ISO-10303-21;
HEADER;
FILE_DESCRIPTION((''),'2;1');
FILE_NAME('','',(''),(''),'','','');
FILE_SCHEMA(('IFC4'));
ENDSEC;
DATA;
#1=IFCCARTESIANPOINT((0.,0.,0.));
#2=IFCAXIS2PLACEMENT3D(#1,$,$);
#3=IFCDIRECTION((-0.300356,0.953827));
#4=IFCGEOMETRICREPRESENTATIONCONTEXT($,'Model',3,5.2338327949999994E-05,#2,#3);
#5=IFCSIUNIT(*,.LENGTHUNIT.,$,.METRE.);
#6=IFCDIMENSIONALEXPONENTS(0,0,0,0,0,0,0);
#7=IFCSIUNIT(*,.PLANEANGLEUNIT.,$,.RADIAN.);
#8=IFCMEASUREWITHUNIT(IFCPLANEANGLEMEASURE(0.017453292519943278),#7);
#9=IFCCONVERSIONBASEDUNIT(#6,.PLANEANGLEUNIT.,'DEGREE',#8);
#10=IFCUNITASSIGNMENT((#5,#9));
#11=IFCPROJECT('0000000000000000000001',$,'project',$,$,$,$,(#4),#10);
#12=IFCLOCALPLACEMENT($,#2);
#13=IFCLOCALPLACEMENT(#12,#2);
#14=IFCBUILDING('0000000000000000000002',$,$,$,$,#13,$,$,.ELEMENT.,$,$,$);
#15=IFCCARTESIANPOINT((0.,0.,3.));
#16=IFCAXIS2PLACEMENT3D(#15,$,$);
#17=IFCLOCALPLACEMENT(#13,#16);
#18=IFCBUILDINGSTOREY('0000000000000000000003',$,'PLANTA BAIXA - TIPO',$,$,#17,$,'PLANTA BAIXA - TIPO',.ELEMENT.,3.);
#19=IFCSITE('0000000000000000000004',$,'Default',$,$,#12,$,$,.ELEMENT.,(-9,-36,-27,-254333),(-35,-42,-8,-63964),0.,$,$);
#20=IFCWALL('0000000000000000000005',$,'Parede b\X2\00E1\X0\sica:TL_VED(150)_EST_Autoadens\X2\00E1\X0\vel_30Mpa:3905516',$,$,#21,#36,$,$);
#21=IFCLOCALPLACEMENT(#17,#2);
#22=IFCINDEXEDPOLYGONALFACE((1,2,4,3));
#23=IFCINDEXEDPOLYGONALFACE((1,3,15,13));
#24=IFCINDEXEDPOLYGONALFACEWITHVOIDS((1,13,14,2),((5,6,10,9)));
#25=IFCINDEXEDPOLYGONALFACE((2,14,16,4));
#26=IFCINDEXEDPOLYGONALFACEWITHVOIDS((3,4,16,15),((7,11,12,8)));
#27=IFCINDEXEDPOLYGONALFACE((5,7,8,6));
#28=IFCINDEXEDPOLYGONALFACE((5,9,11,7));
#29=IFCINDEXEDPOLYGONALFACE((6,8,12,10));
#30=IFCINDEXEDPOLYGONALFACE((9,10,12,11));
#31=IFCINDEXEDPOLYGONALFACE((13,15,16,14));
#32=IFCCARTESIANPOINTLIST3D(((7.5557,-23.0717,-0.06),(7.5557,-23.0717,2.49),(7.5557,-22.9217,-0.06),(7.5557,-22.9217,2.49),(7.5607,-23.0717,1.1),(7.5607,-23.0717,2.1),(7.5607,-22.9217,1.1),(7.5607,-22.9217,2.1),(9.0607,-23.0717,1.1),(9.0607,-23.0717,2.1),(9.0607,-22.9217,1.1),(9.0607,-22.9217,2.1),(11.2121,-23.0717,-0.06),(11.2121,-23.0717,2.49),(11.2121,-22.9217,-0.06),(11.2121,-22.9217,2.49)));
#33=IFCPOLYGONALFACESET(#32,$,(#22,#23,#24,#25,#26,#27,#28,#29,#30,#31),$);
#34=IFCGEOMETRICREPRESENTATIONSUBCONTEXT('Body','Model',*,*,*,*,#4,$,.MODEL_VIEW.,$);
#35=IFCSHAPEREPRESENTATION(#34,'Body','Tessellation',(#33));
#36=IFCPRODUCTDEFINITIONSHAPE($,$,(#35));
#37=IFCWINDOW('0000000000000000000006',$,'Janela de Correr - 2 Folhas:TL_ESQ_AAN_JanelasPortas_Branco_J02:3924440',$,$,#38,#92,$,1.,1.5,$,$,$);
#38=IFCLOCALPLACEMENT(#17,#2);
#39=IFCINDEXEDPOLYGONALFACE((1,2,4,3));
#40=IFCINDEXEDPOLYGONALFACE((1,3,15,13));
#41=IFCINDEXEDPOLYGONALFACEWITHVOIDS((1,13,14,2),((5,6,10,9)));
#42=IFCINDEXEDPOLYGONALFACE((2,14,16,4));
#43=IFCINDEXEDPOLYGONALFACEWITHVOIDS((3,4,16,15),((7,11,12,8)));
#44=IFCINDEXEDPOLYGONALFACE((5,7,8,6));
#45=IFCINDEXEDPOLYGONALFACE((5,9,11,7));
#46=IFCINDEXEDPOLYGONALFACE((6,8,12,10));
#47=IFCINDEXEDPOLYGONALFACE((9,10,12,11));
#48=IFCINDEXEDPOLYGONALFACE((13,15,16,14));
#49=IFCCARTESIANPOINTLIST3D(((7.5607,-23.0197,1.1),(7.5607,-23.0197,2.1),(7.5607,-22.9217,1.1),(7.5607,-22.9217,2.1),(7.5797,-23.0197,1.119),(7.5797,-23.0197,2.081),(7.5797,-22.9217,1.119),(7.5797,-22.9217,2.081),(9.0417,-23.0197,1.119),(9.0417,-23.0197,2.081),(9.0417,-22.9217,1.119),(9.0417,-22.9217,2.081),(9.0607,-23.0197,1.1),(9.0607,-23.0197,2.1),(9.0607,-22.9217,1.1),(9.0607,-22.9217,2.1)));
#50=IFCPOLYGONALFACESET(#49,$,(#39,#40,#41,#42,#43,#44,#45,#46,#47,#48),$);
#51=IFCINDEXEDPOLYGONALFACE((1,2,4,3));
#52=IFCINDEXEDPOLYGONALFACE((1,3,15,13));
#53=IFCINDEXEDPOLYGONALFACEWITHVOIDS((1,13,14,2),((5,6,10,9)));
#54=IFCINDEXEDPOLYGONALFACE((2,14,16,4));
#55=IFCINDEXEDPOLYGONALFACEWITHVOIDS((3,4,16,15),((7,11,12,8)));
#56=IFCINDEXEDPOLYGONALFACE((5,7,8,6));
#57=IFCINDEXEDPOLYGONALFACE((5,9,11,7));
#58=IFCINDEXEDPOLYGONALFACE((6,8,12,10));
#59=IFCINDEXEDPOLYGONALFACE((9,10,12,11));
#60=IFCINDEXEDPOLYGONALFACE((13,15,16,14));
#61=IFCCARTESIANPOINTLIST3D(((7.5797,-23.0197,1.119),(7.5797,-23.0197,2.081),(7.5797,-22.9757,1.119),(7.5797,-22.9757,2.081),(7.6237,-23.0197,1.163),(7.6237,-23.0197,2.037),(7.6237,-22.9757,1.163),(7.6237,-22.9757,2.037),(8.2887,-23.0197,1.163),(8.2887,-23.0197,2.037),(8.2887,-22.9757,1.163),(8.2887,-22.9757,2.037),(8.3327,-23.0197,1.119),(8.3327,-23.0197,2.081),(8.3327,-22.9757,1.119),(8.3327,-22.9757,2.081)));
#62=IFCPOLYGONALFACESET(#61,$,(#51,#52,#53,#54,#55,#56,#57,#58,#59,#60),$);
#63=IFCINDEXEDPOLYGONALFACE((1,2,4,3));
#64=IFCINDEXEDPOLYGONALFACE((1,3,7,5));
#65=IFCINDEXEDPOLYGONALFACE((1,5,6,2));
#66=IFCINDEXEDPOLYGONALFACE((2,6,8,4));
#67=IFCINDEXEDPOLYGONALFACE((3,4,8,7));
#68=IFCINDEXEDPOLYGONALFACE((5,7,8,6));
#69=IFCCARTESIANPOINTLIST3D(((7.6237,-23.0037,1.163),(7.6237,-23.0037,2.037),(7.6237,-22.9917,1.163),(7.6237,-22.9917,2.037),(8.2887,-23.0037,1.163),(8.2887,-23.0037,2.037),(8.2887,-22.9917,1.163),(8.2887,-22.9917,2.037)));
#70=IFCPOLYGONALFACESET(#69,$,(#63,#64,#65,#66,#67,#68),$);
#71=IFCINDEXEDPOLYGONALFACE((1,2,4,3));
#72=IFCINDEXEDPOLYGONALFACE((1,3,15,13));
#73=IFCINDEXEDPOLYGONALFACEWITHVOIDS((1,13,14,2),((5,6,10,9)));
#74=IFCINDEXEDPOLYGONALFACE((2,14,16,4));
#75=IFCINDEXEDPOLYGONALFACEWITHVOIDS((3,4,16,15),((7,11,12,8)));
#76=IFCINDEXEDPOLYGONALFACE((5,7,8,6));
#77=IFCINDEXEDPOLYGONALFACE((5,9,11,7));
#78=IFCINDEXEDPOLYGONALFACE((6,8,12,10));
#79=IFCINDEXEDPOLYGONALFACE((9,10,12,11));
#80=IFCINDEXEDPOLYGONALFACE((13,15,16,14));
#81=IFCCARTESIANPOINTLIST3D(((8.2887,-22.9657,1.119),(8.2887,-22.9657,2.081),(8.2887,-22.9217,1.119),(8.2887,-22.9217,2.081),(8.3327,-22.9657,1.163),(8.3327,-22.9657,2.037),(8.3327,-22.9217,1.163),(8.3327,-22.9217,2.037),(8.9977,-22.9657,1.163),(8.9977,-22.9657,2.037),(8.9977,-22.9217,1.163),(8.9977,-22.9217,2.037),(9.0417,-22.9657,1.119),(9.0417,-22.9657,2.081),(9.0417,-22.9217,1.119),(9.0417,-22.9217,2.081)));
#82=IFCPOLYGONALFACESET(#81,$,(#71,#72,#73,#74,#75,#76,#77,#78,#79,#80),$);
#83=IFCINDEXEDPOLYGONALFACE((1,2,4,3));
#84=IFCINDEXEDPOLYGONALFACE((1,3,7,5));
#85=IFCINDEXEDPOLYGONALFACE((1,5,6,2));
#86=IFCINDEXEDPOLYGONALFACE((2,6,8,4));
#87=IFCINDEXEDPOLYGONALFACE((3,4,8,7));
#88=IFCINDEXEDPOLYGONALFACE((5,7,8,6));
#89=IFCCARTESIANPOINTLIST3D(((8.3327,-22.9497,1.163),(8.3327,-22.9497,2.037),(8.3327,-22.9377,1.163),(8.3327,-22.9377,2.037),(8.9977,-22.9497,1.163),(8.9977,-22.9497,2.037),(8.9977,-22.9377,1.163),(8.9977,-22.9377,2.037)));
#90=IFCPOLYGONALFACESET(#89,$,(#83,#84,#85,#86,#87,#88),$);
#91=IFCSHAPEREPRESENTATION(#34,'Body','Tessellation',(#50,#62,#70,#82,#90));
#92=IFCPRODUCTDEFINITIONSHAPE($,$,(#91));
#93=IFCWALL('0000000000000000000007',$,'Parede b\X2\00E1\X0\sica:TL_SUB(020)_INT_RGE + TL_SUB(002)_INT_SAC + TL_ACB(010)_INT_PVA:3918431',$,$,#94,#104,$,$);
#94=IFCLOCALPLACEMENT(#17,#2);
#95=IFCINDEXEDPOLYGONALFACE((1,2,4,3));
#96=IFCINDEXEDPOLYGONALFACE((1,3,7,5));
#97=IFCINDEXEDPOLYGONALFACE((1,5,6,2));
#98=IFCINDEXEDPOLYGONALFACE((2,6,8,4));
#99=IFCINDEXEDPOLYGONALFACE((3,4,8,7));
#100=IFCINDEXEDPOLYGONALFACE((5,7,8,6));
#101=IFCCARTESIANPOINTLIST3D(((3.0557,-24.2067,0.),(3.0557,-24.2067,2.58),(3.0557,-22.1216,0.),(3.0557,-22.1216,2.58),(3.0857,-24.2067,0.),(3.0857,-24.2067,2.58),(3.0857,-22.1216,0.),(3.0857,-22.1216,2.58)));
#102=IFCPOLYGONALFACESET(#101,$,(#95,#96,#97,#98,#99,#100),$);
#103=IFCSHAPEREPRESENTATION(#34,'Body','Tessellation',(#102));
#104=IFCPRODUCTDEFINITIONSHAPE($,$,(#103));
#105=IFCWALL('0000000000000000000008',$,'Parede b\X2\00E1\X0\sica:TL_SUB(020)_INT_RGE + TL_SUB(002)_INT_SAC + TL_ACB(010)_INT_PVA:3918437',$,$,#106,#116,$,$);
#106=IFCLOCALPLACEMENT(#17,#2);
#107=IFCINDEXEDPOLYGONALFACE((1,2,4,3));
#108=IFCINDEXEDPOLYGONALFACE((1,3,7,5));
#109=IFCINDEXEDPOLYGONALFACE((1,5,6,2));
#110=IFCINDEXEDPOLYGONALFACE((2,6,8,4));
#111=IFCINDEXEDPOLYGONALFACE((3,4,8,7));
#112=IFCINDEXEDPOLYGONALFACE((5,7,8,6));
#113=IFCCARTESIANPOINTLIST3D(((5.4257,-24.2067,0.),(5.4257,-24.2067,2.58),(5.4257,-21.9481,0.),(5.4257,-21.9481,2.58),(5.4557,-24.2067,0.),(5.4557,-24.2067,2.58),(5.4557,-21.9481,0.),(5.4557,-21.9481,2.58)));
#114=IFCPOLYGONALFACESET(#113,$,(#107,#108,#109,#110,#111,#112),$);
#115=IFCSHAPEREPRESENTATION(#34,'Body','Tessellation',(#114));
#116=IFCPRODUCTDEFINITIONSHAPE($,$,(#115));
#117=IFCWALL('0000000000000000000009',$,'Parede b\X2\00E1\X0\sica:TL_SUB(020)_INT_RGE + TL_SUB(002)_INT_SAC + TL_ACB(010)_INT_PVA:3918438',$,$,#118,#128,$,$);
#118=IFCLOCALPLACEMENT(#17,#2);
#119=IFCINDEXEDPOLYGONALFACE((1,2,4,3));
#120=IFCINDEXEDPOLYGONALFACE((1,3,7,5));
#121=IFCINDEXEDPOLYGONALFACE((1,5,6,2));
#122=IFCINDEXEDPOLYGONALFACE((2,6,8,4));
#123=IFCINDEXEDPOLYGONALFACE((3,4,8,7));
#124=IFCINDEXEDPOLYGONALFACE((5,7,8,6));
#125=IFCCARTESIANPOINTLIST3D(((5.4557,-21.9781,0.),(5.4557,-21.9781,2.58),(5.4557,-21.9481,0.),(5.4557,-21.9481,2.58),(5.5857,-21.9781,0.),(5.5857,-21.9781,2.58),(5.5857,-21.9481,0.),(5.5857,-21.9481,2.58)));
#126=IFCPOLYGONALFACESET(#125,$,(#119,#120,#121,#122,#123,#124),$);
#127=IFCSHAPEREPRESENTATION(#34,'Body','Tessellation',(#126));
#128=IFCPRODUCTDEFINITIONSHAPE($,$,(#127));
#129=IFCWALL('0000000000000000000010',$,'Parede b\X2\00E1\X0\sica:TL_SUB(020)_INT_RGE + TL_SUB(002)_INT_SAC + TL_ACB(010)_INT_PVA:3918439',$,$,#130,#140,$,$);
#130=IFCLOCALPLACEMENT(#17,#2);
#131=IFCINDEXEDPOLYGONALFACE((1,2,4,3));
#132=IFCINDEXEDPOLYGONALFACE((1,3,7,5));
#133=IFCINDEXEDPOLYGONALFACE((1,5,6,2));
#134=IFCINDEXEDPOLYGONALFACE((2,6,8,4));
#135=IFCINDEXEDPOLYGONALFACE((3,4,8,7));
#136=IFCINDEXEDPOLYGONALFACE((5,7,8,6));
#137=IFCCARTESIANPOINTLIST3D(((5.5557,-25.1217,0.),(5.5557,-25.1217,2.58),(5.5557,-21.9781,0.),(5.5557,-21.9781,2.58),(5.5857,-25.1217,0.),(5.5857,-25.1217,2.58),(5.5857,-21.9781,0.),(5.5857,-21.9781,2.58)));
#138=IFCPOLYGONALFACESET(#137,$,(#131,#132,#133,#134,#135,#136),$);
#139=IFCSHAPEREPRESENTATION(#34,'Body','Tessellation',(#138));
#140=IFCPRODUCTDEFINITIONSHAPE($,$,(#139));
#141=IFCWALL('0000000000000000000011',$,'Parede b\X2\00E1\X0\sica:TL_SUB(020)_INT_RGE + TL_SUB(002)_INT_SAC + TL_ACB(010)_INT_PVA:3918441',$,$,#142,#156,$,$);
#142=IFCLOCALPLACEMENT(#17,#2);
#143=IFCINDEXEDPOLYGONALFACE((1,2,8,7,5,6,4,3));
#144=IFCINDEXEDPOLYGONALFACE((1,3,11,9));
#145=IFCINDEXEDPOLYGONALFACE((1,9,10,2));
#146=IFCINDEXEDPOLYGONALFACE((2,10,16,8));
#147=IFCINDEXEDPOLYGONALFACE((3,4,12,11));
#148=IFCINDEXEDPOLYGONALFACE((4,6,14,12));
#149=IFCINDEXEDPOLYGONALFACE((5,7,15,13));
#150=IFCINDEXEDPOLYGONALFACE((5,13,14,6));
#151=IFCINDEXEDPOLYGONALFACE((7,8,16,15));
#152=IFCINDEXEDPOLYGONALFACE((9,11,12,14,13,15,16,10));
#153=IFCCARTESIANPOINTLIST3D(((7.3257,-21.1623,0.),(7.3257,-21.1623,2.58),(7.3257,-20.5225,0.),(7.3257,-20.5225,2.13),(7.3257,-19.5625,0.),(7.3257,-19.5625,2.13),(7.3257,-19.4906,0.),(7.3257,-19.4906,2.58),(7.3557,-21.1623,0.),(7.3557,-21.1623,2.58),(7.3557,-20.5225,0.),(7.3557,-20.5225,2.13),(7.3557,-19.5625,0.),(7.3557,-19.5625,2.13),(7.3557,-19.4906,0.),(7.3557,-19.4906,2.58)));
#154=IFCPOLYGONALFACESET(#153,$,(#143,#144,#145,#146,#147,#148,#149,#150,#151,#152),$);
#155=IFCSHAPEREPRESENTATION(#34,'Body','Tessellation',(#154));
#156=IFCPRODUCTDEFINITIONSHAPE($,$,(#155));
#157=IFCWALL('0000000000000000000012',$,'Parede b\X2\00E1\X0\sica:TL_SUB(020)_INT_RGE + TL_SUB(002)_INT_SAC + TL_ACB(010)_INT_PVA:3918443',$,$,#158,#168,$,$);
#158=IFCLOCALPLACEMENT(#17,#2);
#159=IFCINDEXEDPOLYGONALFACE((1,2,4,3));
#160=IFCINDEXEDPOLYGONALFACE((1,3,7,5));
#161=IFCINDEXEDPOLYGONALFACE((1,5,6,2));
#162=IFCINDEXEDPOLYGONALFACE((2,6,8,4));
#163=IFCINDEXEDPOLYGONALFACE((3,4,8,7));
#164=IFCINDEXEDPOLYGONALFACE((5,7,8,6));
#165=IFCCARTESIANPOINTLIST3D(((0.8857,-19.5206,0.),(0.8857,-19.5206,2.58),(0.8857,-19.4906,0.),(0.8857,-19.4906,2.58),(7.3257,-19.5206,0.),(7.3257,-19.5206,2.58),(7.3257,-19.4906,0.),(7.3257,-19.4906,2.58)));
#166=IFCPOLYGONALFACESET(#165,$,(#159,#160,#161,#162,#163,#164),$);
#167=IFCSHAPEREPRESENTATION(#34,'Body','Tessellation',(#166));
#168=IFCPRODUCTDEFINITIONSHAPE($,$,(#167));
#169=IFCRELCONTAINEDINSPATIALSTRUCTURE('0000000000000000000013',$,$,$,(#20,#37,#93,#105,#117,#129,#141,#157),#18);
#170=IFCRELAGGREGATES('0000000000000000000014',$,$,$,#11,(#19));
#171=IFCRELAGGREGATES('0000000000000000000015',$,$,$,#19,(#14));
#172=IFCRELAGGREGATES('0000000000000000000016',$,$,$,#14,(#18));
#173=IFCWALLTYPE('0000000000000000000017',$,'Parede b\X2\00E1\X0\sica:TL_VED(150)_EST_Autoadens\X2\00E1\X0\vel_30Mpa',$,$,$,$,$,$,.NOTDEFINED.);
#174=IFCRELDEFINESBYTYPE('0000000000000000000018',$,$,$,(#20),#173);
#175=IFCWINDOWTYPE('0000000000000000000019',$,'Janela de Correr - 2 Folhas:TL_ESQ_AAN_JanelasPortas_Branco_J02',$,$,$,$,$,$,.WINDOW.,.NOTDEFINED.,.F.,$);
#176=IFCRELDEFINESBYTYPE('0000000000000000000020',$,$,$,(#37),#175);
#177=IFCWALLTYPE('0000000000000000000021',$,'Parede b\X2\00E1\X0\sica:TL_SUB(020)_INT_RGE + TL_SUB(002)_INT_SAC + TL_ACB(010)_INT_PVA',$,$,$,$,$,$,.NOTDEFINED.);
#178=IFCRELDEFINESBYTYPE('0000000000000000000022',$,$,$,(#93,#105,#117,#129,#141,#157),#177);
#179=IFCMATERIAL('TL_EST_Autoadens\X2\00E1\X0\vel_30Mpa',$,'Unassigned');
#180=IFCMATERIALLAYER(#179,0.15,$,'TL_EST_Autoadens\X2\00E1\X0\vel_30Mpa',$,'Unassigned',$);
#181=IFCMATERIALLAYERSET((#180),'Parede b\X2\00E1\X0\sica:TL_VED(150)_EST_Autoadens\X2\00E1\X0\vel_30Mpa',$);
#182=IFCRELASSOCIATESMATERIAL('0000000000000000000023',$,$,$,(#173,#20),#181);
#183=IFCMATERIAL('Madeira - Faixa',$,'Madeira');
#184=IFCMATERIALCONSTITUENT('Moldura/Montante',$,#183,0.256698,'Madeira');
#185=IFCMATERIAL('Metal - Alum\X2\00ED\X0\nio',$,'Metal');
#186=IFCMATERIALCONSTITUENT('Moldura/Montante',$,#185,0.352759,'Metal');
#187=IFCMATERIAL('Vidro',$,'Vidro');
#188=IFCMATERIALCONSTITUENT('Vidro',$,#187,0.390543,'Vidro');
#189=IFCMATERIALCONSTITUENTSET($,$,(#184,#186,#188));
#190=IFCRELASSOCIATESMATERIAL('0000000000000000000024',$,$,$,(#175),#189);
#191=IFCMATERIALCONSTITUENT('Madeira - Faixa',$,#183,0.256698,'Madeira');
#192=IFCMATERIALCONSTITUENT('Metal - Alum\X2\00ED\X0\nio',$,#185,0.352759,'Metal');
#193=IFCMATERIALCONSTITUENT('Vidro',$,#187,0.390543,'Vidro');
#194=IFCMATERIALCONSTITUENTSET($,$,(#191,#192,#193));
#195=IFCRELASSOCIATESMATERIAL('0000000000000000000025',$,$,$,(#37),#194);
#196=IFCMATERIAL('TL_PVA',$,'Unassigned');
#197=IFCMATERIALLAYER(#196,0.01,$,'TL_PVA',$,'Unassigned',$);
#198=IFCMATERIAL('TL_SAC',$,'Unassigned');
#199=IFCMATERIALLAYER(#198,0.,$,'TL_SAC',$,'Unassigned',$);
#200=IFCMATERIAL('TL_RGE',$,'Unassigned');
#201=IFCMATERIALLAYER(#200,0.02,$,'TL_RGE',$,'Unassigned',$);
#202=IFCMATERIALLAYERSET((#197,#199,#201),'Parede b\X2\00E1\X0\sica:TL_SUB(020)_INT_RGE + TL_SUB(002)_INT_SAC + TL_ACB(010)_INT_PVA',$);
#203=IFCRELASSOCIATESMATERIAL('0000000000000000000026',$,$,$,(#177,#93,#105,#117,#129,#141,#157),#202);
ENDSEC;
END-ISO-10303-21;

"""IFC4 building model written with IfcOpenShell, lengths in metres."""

from ifc_helpers import new_model, entity, si_unit, converted_unit, direction, frame, frame_2d, origin, origin_2d_with_axis, place, context, subcontext, project, spatial, polyline, rectangle, outline, extrude, source, transform, mapped, material, layer, layer_set, layer_usage, constituent, constituent_set, type_object, type_shapes, element, fill, save


model = new_model("IFC4")

# Units and contexts
model_context = context("Model", 3, precision=5.2338327949999994e-05, world=origin(), true_north=direction((-0.300356, 0.953827)))
body_context = subcontext(model_context, "Body", "Model", "MODEL_VIEW")
ifc_project = project(units=[si_unit("LENGTHUNIT", "METRE"), converted_unit("PLANEANGLEUNIT", "DEGREE", entity("IfcPlaneAngleMeasure", 0.017453292519943278), si_unit("PLANEANGLEUNIT", "RADIAN"), dimensions=[0, 0, 0, 0, 0, 0, 0])], contexts=[model_context])

# Site, building, storey
site_placement = place(None, origin())
site = spatial("IfcSite", under=ifc_project, at=site_placement, Name="Default", CompositionType="ELEMENT", RefLatitude=(-9, -36, -27, -254333), RefLongitude=(-35, -42, -8, -63964), RefElevation=0.0)
building_placement = place(site_placement, origin())
building = spatial("IfcBuilding", under=site, at=building_placement, CompositionType="ELEMENT")
storey_placement = place(building_placement, frame((0.0, 0.0, 3.0)))
storey = spatial("IfcBuildingStorey", under=building, at=storey_placement, Name="PLANTA BAIXA - TIPO", LongName="PLANTA BAIXA - TIPO", CompositionType="ELEMENT", Elevation=3.0)

# Shared definitions
ifc_material_1 = material(Name="TL_EST_Autoadensável_30Mpa", Category="Unassigned")

# Wall, opening, window
ifc_material_2 = material(Name="Madeira - Faixa", Category="Madeira")
ifc_material_3 = material(Name="Metal - Alumínio", Category="Metal")
ifc_material_4 = material(Name="Vidro", Category="Vidro")
ifc_layer_1 = layer(ifc_material_1, 0.15, Name="TL_EST_Autoadensável_30Mpa", Category="Unassigned")
ifc_layer_set_1 = layer_set([ifc_layer_1], Name="Parede básica:TL_VED(150)_EST_Autoadensável_30Mpa")
ifc_layer_usage_1 = layer_usage(ifc_layer_set_1, "AXIS2", "POSITIVE", -0.075)
wall_type_1 = type_object("IfcWallType", Name="Parede básica:TL_VED(150)_EST_Autoadensável_30Mpa", PredefinedType="NOTDEFINED", material=ifc_layer_set_1)
wall_1_placement = place(storey_placement, frame((7.5557, -22.9967, -0.06)))
wall_1 = element("IfcWall", 1, at=wall_1_placement, inside=storey, type_object=wall_type_1, material=ifc_layer_usage_1, Name="Parede básica:TL_VED(150)_EST_Autoadensável_30Mpa:3905516", context=body_context, shape_type="SweptSolid", body=[
    extrude(rectangle(XDim=3.6564, YDim=0.15, at=frame_2d((1.8282, 0.0), x_axis=(-1.0, 0.0))), origin(), (0.0, 0.0, 1.0), 2.55),
])
opening_1_placement = place(wall_1_placement, frame((1.505, 0.075, 1.16)))
opening_1 = element("IfcOpeningElement", 2, at=opening_1_placement, cuts=wall_1, PredefinedType="OPENING", context=body_context, shape_type="SweptSolid", body=[
    extrude(rectangle(XDim=1.0, YDim=1.5, at=frame_2d((0.5, 0.75), x_axis=(-1.0, 0.0))), frame((0.0, 0.0, 0.0), z_axis=(0.0, -1.0, 0.0), x_axis=(0.0, 0.0, 1.0)), (0.0, 0.0, 1.0), 0.15),
])
ifc_constituent_1 = constituent(ifc_material_2, Name="Madeira - Faixa", Category="Madeira", fraction=0.256698)
ifc_constituent_2 = constituent(ifc_material_3, Name="Metal - Alumínio", Category="Metal", fraction=0.352759)
ifc_constituent_3 = constituent(ifc_material_4, Name="Vidro", Category="Vidro", fraction=0.390543)
ifc_constituent_set_1 = constituent_set(constituents=[ifc_constituent_1, ifc_constituent_2, ifc_constituent_3])
ifc_constituent_4 = constituent(ifc_material_2, Name="Moldura/Montante", Category="Madeira", fraction=0.256698)
ifc_constituent_5 = constituent(ifc_material_3, Name="Moldura/Montante", Category="Metal", fraction=0.352759)
ifc_constituent_6 = constituent(ifc_material_4, Name="Vidro", Category="Vidro", fraction=0.390543)
ifc_constituent_set_2 = constituent_set(constituents=[ifc_constituent_4, ifc_constituent_5, ifc_constituent_6])
window_type_1 = type_object("IfcWindowType", Name="Janela de Correr - 2 Folhas:TL_ESQ_AAN_JanelasPortas_Branco_J02", ParameterTakesPrecedence=False, PartitioningType="NOTDEFINED", PredefinedType="WINDOW", material=ifc_constituent_set_2)
shared_shape_1 = source(origin(), body_context, "Body", "SweptSolid", [
    extrude(outline(polyline([(-0.75, -0.5), (0.75, -0.5), (0.75, 0.5), (-0.75, 0.5), (-0.75, -0.5)]), holes=[polyline([(-0.731, -0.481), (-0.731, 0.481), (0.731, 0.481), (0.731, -0.481), (-0.731, -0.481)])]), frame((0.75, 0.0, 0.5), z_axis=(0.0, 1.0, 0.0), x_axis=(1.0, 0.0, 0.0)), (0.0, 0.0, 1.0), 0.098),
    extrude(outline(polyline([(-0.3765, -0.481), (0.3765, -0.481), (0.3765, 0.481), (-0.3765, 0.481), (-0.3765, -0.481)]), holes=[polyline([(-0.3325, -0.437), (-0.3325, 0.437), (0.3325, 0.437), (0.3325, -0.437), (-0.3325, -0.437)])]), frame((1.1045, 0.054, 0.5), z_axis=(0.0, 1.0, 0.0), x_axis=(1.0, 0.0, 0.0)), (0.0, 0.0, 1.0), 0.044),
    extrude(rectangle(XDim=0.012, YDim=0.665, at=origin_2d_with_axis()), frame((1.1045, 0.076, 0.063), z_axis=(0.0, 0.0, 1.0), x_axis=(0.0, -1.0, 0.0)), (0.0, 0.0, 1.0), 0.874),
    extrude(outline(polyline([(-0.481, -0.3765), (0.481, -0.3765), (0.481, 0.3765), (-0.481, 0.3765), (-0.481, -0.3765)]), holes=[polyline([(-0.437, -0.3325), (-0.437, 0.3325), (0.437, 0.3325), (0.437, -0.3325), (-0.437, -0.3325)])]), frame((0.3955, 0.0, 0.5), z_axis=(0.0, 1.0, 0.0), x_axis=(0.0, 0.0, -1.0)), (0.0, 0.0, 1.0), 0.044),
    extrude(rectangle(XDim=0.012, YDim=0.665, at=origin_2d_with_axis()), frame((0.3955, 0.022, 0.063), z_axis=(0.0, 0.0, 1.0), x_axis=(0.0, -1.0, 0.0)), (0.0, 0.0, 1.0), 0.874),
])
type_shapes(window_type_1, [shared_shape_1])
window_1_placement = place(opening_1_placement, frame((0.0, 0.0, 0.0), z_axis=(0.0, 0.0, 1.0), x_axis=(-1.0, 0.0, 0.0)))
window_1 = element("IfcWindow", 3, at=window_1_placement, inside=storey, type_object=window_type_1, material=ifc_constituent_set_1, Name="Janela de Correr - 2 Folhas:TL_ESQ_AAN_JanelasPortas_Branco_J02:3924440", OverallHeight=1.0, OverallWidth=1.5, context=body_context, shape_type="MappedRepresentation", body=[
    mapped(shared_shape_1, transform((0.0, 0.0, 0.0), scale=1.0)),
])
fill(opening_1, window_1)

# Walls
ifc_material_5 = material(Name="TL_PVA", Category="Unassigned")
ifc_layer_2 = layer(ifc_material_5, 0.01, Name="TL_PVA", Category="Unassigned")
ifc_material_6 = material(Name="TL_SAC", Category="Unassigned")
ifc_layer_3 = layer(ifc_material_6, 0.0, Name="TL_SAC", Category="Unassigned")
ifc_material_7 = material(Name="TL_RGE", Category="Unassigned")
ifc_layer_4 = layer(ifc_material_7, 0.02, Name="TL_RGE", Category="Unassigned")
ifc_layer_set_2 = layer_set([ifc_layer_2, ifc_layer_3, ifc_layer_4], Name="Parede básica:TL_SUB(020)_INT_RGE + TL_SUB(002)_INT_SAC + TL_ACB(010)_INT_PVA")
ifc_layer_usage_2 = layer_usage(ifc_layer_set_2, "AXIS2", "POSITIVE", -0.015)
wall_type_2 = type_object("IfcWallType", Name="Parede básica:TL_SUB(020)_INT_RGE + TL_SUB(002)_INT_SAC + TL_ACB(010)_INT_PVA", PredefinedType="NOTDEFINED", material=ifc_layer_set_2)
wall_2_placement = place(storey_placement, frame((3.0707, -24.2067, 0.0), z_axis=(0.0, 0.0, 1.0), x_axis=(0.0, 1.0, 0.0)))
element("IfcWall", 4, at=wall_2_placement, inside=storey, type_object=wall_type_2, material=ifc_layer_usage_2, Name="Parede básica:TL_SUB(020)_INT_RGE + TL_SUB(002)_INT_SAC + TL_ACB(010)_INT_PVA:3918431", context=body_context, shape_type="SweptSolid", body=[
    extrude(rectangle(XDim=2.0851, YDim=0.03, at=frame_2d((1.0426, 0.0), x_axis=(-1.0, 0.0))), origin(), (0.0, 0.0, 1.0), 2.58),
])
ifc_layer_usage_3 = layer_usage(ifc_layer_set_2, "AXIS2", "POSITIVE", -0.015)
wall_3_placement = place(storey_placement, frame((5.4407, -21.9481, 0.0), z_axis=(0.0, 0.0, 1.0), x_axis=(0.0, -1.0, 0.0)))
element("IfcWall", 5, at=wall_3_placement, inside=storey, type_object=wall_type_2, material=ifc_layer_usage_3, Name="Parede básica:TL_SUB(020)_INT_RGE + TL_SUB(002)_INT_SAC + TL_ACB(010)_INT_PVA:3918437", context=body_context, shape_type="SweptSolid", body=[
    extrude(rectangle(XDim=2.2587, YDim=0.03, at=frame_2d((1.1293, 0.0), x_axis=(-1.0, 0.0))), origin(), (0.0, 0.0, 1.0), 2.58),
])
ifc_layer_usage_4 = layer_usage(ifc_layer_set_2, "AXIS2", "POSITIVE", -0.015)
wall_4_placement = place(storey_placement, frame((5.5857, -21.9631, 0.0), z_axis=(0.0, 0.0, 1.0), x_axis=(-1.0, 0.0, 0.0)))
element("IfcWall", 6, at=wall_4_placement, inside=storey, type_object=wall_type_2, material=ifc_layer_usage_4, Name="Parede básica:TL_SUB(020)_INT_RGE + TL_SUB(002)_INT_SAC + TL_ACB(010)_INT_PVA:3918438", context=body_context, shape_type="SweptSolid", body=[
    extrude(rectangle(XDim=0.13, YDim=0.03, at=frame_2d((0.065, 0.0), x_axis=(-1.0, 0.0))), origin(), (0.0, 0.0, 1.0), 2.58),
])
ifc_layer_usage_5 = layer_usage(ifc_layer_set_2, "AXIS2", "POSITIVE", -0.015)
wall_5_placement = place(storey_placement, frame((5.5707, -25.1217, 0.0), z_axis=(0.0, 0.0, 1.0), x_axis=(0.0, 1.0, 0.0)))
element("IfcWall", 7, at=wall_5_placement, inside=storey, type_object=wall_type_2, material=ifc_layer_usage_5, Name="Parede básica:TL_SUB(020)_INT_RGE + TL_SUB(002)_INT_SAC + TL_ACB(010)_INT_PVA:3918439", context=body_context, shape_type="SweptSolid", body=[
    extrude(rectangle(XDim=3.1437, YDim=0.03, at=frame_2d((1.5718, 0.0), x_axis=(-1.0, 0.0))), origin(), (0.0, 0.0, 1.0), 2.58),
])

# Wall, opening
ifc_layer_usage_6 = layer_usage(ifc_layer_set_2, "AXIS2", "POSITIVE", -0.015)
wall_6_placement = place(storey_placement, frame((7.3407, -19.4906, 0.0), z_axis=(0.0, 0.0, 1.0), x_axis=(0.0, -1.0, 0.0)))
wall_6 = element("IfcWall", 8, at=wall_6_placement, inside=storey, type_object=wall_type_2, material=ifc_layer_usage_6, Name="Parede básica:TL_SUB(020)_INT_RGE + TL_SUB(002)_INT_SAC + TL_ACB(010)_INT_PVA:3918441", context=body_context, shape_type="SweptSolid", body=[
    extrude(rectangle(XDim=1.6717, YDim=0.03, at=frame_2d((0.8359, 0.0), x_axis=(-1.0, 0.0))), origin(), (0.0, 0.0, 1.0), 2.58),
])
opening_2_placement = place(wall_6_placement, frame((-19.4906, -7.3407, 0.0)))
element("IfcOpeningElement", 9, at=opening_2_placement, cuts=wall_6, PredefinedType="OPENING", context=body_context, shape_type="SweptSolid", body=[
    extrude(rectangle(XDim=2.13, YDim=0.96, at=frame_2d((0.0, 0.0), x_axis=(0.0, 1.0))), frame((20.0425, 5.8317, 1.065), z_axis=(0.0, 1.0, 0.0), x_axis=(-1.0, 0.0, 0.0)), (0.0, 0.0, 1.0), 3.048),
])

# Wall
ifc_layer_usage_7 = layer_usage(ifc_layer_set_2, "AXIS2", "NEGATIVE", 0.015)
wall_7_placement = place(storey_placement, frame((7.3257, -19.5056, 0.0), z_axis=(0.0, 0.0, 1.0), x_axis=(-1.0, 0.0, 0.0)))
element("IfcWall", 10, at=wall_7_placement, inside=storey, type_object=wall_type_2, material=ifc_layer_usage_7, Name="Parede básica:TL_SUB(020)_INT_RGE + TL_SUB(002)_INT_SAC + TL_ACB(010)_INT_PVA:3918443", context=body_context, shape_type="SweptSolid", body=[
    extrude(rectangle(XDim=6.44, YDim=0.03, at=frame_2d((3.22, 0.0), x_axis=(-1.0, 0.0))), origin(), (0.0, 0.0, 1.0), 2.58),
])

save(model, "model.ifc")
